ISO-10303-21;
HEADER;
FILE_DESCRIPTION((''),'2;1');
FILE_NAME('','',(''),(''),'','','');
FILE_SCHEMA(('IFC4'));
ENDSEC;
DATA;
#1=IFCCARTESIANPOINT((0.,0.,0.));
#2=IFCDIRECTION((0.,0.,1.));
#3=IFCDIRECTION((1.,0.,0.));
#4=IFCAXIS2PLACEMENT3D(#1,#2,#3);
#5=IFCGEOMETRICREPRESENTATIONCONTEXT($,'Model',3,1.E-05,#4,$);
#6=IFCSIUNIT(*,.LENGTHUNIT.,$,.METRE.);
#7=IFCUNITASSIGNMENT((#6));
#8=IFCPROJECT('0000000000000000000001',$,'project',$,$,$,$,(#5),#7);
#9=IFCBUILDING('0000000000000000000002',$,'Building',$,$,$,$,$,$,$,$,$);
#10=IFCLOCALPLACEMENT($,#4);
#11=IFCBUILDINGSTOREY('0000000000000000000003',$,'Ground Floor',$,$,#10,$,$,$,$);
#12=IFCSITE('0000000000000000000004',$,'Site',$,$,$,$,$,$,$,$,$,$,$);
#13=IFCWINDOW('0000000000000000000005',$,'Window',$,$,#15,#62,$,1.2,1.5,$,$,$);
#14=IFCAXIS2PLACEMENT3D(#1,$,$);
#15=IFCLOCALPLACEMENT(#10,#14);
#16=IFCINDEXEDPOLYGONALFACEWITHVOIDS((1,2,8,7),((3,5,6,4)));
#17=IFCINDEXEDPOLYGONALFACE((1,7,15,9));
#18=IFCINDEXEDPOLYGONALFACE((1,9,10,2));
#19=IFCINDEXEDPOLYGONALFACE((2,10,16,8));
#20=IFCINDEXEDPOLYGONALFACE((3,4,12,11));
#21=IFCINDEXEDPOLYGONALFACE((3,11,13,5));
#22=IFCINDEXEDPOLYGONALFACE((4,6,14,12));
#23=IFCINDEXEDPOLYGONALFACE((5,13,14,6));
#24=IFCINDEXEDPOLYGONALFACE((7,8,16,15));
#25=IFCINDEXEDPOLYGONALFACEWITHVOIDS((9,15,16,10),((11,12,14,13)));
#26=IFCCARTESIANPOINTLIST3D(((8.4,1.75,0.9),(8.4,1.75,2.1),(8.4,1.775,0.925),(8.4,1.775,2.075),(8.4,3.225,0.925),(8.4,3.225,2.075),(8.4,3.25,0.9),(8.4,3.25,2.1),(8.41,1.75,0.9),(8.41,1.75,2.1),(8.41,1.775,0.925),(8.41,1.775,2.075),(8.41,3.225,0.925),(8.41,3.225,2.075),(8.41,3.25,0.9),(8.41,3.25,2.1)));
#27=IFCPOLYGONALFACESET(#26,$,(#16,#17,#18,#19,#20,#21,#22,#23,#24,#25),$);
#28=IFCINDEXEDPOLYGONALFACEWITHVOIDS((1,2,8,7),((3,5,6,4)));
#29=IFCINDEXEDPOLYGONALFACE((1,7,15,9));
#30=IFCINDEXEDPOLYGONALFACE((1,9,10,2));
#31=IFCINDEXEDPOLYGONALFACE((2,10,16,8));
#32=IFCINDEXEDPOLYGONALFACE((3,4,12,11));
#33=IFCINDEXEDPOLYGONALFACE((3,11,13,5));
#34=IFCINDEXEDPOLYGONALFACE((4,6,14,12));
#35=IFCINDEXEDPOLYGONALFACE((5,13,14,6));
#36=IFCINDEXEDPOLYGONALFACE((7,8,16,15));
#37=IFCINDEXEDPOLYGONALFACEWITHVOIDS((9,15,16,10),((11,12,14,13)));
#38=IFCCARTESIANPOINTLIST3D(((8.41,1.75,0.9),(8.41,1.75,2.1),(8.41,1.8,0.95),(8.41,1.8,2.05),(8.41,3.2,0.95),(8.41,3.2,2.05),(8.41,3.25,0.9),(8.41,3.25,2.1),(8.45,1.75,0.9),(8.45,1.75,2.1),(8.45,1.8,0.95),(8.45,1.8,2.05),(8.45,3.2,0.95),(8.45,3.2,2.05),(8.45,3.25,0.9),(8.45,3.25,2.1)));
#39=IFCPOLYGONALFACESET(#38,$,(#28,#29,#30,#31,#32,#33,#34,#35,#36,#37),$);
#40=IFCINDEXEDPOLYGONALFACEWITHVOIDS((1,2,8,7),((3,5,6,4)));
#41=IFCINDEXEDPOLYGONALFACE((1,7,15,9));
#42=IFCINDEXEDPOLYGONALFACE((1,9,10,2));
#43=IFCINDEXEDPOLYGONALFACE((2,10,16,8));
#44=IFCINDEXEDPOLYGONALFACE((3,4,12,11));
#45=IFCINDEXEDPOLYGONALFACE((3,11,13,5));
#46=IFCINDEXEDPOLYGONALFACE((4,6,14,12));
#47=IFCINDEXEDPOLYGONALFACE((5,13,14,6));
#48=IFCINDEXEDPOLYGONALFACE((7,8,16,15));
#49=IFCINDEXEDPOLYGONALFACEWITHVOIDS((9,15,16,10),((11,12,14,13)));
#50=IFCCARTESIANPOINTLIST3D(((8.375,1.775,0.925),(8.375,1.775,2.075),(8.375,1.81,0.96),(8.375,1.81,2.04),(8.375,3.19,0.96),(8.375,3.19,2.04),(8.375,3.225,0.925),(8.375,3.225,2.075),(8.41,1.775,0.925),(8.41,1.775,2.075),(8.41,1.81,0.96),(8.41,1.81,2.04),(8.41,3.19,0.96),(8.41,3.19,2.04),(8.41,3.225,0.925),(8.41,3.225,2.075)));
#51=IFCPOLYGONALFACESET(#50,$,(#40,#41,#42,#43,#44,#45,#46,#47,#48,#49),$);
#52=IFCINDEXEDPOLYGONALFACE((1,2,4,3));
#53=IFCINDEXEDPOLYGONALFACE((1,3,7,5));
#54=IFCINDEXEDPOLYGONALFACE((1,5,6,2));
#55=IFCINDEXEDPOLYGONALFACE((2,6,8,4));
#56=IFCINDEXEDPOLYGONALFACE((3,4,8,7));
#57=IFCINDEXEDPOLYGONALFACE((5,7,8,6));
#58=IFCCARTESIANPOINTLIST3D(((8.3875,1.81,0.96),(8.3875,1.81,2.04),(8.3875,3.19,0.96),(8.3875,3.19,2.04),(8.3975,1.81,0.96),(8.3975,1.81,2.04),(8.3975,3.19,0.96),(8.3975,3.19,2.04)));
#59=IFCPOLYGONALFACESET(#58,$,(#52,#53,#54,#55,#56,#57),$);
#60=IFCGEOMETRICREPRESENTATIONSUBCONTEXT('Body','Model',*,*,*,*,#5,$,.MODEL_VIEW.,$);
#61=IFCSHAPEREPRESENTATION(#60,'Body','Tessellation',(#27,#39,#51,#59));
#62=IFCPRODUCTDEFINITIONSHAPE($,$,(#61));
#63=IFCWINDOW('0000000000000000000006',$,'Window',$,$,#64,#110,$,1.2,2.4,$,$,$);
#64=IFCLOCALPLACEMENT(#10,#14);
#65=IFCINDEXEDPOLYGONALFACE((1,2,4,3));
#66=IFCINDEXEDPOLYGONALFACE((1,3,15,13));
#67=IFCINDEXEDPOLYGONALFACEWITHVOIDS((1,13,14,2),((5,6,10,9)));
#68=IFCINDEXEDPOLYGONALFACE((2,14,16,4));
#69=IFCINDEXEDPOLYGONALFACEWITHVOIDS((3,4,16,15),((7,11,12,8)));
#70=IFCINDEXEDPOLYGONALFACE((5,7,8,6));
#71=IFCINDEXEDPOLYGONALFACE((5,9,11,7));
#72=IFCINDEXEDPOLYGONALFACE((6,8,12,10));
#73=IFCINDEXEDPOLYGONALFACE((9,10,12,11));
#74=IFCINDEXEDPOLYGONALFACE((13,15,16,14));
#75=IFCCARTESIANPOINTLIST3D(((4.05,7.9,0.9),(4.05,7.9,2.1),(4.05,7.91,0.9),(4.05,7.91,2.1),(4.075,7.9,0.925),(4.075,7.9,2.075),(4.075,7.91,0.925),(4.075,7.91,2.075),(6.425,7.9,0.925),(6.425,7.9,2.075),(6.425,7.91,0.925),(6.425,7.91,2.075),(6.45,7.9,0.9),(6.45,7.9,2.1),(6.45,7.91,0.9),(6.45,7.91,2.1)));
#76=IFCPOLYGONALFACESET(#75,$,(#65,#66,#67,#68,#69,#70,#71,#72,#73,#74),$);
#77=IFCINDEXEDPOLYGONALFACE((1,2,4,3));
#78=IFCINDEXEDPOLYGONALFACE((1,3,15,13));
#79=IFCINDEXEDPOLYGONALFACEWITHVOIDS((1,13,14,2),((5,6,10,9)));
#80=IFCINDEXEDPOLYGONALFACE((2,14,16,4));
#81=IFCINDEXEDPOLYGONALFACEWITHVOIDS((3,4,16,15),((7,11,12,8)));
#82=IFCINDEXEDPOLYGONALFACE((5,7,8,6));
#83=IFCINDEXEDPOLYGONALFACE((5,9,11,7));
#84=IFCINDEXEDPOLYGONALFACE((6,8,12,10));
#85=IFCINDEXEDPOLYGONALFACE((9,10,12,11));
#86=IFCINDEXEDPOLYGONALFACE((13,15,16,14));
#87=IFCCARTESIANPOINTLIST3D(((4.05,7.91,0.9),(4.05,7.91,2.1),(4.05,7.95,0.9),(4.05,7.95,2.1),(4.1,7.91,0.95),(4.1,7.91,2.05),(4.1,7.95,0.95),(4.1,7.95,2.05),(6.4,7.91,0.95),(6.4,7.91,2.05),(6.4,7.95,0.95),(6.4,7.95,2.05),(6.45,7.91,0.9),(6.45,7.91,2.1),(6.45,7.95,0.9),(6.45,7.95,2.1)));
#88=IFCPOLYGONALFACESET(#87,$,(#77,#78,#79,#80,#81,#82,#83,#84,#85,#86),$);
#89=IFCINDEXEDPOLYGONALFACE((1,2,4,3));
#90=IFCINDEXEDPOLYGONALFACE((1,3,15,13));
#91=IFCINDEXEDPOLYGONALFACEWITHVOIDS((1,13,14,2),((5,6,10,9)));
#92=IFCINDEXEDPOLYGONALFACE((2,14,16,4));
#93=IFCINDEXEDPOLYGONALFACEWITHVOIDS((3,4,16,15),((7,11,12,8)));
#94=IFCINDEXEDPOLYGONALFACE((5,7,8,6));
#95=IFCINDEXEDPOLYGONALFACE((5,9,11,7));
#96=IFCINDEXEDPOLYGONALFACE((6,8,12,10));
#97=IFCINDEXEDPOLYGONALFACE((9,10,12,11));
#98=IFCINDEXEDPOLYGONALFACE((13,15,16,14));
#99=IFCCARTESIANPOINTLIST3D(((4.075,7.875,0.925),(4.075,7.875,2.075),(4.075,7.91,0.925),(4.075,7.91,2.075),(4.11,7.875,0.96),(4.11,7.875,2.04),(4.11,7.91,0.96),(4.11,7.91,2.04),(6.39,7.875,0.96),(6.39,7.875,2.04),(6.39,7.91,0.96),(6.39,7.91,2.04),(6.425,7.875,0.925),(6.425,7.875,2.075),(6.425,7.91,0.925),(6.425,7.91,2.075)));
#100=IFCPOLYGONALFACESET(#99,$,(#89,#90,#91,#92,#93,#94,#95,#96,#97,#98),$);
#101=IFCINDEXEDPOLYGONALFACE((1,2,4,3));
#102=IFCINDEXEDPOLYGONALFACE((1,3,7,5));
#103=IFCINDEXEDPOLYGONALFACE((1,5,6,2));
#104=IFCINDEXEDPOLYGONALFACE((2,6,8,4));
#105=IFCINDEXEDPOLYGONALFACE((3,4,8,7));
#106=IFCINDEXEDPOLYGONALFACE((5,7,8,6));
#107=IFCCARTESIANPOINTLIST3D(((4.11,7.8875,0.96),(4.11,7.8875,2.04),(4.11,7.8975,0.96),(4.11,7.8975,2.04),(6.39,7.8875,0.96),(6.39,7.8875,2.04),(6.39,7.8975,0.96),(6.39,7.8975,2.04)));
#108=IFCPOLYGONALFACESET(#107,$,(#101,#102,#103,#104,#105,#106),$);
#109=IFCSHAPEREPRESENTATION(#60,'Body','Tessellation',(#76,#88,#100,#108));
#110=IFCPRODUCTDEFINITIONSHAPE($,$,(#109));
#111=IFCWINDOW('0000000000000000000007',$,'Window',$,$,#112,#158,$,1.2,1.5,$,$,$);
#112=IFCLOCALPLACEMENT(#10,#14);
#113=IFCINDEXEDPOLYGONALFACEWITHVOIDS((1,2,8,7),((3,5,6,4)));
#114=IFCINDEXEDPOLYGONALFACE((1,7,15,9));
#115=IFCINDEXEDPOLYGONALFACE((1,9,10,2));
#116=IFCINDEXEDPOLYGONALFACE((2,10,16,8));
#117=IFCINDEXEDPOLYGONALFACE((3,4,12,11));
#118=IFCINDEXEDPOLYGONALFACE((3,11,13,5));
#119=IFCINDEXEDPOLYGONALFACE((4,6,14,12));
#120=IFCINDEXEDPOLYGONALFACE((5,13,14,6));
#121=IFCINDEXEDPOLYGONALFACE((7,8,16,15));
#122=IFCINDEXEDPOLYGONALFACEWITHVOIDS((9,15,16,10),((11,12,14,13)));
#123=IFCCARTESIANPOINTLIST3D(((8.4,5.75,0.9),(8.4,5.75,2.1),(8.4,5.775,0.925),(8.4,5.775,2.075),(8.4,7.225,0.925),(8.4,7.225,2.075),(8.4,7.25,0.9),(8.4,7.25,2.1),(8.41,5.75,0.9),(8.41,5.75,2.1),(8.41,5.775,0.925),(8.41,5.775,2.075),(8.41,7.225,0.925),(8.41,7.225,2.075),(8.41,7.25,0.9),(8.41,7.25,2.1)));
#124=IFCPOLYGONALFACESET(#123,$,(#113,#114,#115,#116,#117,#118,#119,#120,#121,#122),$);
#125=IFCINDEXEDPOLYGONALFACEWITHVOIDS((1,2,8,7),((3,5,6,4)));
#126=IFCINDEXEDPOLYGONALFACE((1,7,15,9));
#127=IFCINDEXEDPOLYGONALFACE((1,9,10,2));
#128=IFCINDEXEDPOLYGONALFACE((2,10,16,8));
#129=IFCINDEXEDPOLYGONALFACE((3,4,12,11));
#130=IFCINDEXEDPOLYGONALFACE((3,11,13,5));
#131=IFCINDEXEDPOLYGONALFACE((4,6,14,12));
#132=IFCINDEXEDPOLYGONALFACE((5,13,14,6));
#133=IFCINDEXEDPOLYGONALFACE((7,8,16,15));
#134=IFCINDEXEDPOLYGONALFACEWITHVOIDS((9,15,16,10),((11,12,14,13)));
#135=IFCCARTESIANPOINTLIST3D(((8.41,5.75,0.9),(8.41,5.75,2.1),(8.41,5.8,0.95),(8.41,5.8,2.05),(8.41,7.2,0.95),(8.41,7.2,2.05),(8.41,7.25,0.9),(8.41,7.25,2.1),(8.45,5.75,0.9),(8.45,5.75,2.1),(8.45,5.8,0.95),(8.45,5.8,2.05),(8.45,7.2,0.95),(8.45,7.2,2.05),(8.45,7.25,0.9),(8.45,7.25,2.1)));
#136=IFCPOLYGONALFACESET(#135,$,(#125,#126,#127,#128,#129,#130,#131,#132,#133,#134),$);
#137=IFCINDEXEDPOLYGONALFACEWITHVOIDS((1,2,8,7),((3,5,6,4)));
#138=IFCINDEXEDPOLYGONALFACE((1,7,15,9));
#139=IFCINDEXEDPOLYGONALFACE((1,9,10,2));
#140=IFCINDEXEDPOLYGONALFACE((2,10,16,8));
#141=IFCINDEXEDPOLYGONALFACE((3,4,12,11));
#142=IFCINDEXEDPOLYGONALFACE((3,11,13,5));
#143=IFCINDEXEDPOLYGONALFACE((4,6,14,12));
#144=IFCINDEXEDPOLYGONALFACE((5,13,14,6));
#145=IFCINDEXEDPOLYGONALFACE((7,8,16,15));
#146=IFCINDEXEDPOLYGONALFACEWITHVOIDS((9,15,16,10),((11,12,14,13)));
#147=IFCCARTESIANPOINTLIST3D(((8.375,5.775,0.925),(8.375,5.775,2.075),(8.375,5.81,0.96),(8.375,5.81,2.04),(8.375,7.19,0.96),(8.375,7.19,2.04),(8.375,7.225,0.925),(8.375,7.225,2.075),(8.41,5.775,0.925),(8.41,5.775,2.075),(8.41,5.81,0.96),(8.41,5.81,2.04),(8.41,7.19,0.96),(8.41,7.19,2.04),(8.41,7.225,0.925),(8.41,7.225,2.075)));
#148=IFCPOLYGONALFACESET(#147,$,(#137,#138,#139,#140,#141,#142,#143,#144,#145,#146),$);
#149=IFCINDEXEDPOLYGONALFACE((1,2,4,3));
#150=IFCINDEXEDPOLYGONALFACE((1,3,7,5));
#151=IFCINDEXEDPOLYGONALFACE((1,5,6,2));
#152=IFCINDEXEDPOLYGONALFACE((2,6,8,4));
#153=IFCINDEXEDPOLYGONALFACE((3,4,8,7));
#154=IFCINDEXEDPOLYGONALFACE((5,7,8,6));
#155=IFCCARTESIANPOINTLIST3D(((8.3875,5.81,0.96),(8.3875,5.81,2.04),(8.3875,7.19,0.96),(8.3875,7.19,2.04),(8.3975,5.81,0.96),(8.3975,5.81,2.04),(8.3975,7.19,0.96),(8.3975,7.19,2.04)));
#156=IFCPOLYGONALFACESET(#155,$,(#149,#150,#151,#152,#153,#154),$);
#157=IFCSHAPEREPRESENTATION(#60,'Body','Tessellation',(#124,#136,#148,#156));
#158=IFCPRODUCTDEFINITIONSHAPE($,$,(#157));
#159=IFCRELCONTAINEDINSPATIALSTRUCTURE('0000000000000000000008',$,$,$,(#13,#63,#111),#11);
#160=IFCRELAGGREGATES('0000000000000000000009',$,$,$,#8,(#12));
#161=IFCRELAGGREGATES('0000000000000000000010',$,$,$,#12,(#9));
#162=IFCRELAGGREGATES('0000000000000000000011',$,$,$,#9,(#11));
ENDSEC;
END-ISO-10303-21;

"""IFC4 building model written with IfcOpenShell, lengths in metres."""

from ifc_helpers import new_model, si_unit, frame, origin_with_axes, place, context, subcontext, project, spatial, line, indexed_curve, outline, extrude, element, save


model = new_model("IFC4")

# Units and contexts
model_context = context("Model", 3, precision=1e-05, world=origin_with_axes())
body_context = subcontext(model_context, "Body", "Model", "MODEL_VIEW")
ifc_project = project(units=[si_unit("LENGTHUNIT", "METRE")], contexts=[model_context])

# Site, building, storey
site = spatial("IfcSite", under=ifc_project, Name="Site")
building = spatial("IfcBuilding", under=site, Name="Building")
storey_placement = place(None, origin_with_axes())
storey = spatial("IfcBuildingStorey", under=building, at=storey_placement, Name="Ground Floor")

# Windows
window_1_placement = place(storey_placement, frame((8.5, 1.75, 0.9), z_axis=(0.0, 0.0, 1.0), x_axis=(0.0, 1.0, 0.0)))
element("IfcWindow", 1, at=window_1_placement, inside=storey, Name="Window", OverallHeight=1.2, OverallWidth=1.5, context=body_context, shape_type="SweptSolid", body=[
    extrude(outline(indexed_curve([(0.0, 0.0), (1.5, 0.0), (1.5, 1.2), (0.0, 1.2)], segments=[line(1, 2, 3, 4, 1)]), holes=[indexed_curve([(0.025, 0.025), (1.475, 0.025), (1.475, 1.175), (0.025, 1.175)], segments=[line(1, 2, 3, 4, 1)])]), frame((0.0, 0.09, 0.0), z_axis=(0.0, -1.0, 0.0), x_axis=(1.0, 0.0, 0.0)), (0.0, 0.0, -1.0), 0.01),
    extrude(outline(indexed_curve([(0.0, 0.0), (1.5, 0.0), (1.5, 1.2), (0.0, 1.2)], segments=[line(1, 2, 3, 4, 1)]), holes=[indexed_curve([(0.05, 0.05), (1.45, 0.05), (1.45, 1.15), (0.05, 1.15)], segments=[line(1, 2, 3, 4, 1)])]), frame((0.0, 0.05, 0.0), z_axis=(0.0, -1.0, 0.0), x_axis=(1.0, 0.0, 0.0)), (0.0, 0.0, -1.0), 0.04),
    extrude(outline(indexed_curve([(0.0, 0.0), (1.45, 0.0), (1.45, 1.15), (0.0, 1.15)], segments=[line(1, 2, 3, 4, 1)]), holes=[indexed_curve([(0.035, 0.035), (1.415, 0.035), (1.415, 1.115), (0.035, 1.115)], segments=[line(1, 2, 3, 4, 1)])]), frame((0.025, 0.09, 0.025), z_axis=(0.0, -1.0, 0.0), x_axis=(1.0, 0.0, 0.0)), (0.0, 0.0, -1.0), 0.035),
    extrude(outline(indexed_curve([(0.035, 0.035), (1.415, 0.035), (1.415, 1.115), (0.035, 1.115)], segments=[line(1, 2, 3, 4, 1)])), frame((0.025, 0.1025, 0.025), z_axis=(0.0, -1.0, 0.0), x_axis=(1.0, 0.0, 0.0)), (0.0, 0.0, -1.0), 0.01),
])
window_2_placement = place(storey_placement, frame((6.45, 8.0, 0.9), z_axis=(0.0, 0.0, 1.0), x_axis=(-1.0, 0.0, 0.0)))
element("IfcWindow", 2, at=window_2_placement, inside=storey, Name="Window", OverallHeight=1.2, OverallWidth=2.4, context=body_context, shape_type="SweptSolid", body=[
    extrude(outline(indexed_curve([(0.0, 0.0), (2.4, 0.0), (2.4, 1.2), (0.0, 1.2)], segments=[line(1, 2, 3, 4, 1)]), holes=[indexed_curve([(0.025, 0.025), (2.375, 0.025), (2.375, 1.175), (0.025, 1.175)], segments=[line(1, 2, 3, 4, 1)])]), frame((0.0, 0.09, 0.0), z_axis=(0.0, -1.0, 0.0), x_axis=(1.0, 0.0, 0.0)), (0.0, 0.0, -1.0), 0.01),
    extrude(outline(indexed_curve([(0.0, 0.0), (2.4, 0.0), (2.4, 1.2), (0.0, 1.2)], segments=[line(1, 2, 3, 4, 1)]), holes=[indexed_curve([(0.05, 0.05), (2.35, 0.05), (2.35, 1.15), (0.05, 1.15)], segments=[line(1, 2, 3, 4, 1)])]), frame((0.0, 0.05, 0.0), z_axis=(0.0, -1.0, 0.0), x_axis=(1.0, 0.0, 0.0)), (0.0, 0.0, -1.0), 0.04),
    extrude(outline(indexed_curve([(0.0, 0.0), (2.35, 0.0), (2.35, 1.15), (0.0, 1.15)], segments=[line(1, 2, 3, 4, 1)]), holes=[indexed_curve([(0.035, 0.035), (2.315, 0.035), (2.315, 1.115), (0.035, 1.115)], segments=[line(1, 2, 3, 4, 1)])]), frame((0.025, 0.09, 0.025), z_axis=(0.0, -1.0, 0.0), x_axis=(1.0, 0.0, 0.0)), (0.0, 0.0, -1.0), 0.035),
    extrude(outline(indexed_curve([(0.035, 0.035), (2.315, 0.035), (2.315, 1.115), (0.035, 1.115)], segments=[line(1, 2, 3, 4, 1)])), frame((0.025, 0.1025, 0.025), z_axis=(0.0, -1.0, 0.0), x_axis=(1.0, 0.0, 0.0)), (0.0, 0.0, -1.0), 0.01),
])
window_3_placement = place(storey_placement, frame((8.5, 5.75, 0.9), z_axis=(0.0, 0.0, 1.0), x_axis=(0.0, 1.0, 0.0)))
element("IfcWindow", 3, at=window_3_placement, inside=storey, Name="Window", OverallHeight=1.2, OverallWidth=1.5, context=body_context, shape_type="SweptSolid", body=[
    extrude(outline(indexed_curve([(0.0, 0.0), (1.5, 0.0), (1.5, 1.2), (0.0, 1.2)], segments=[line(1, 2, 3, 4, 1)]), holes=[indexed_curve([(0.025, 0.025), (1.475, 0.025), (1.475, 1.175), (0.025, 1.175)], segments=[line(1, 2, 3, 4, 1)])]), frame((0.0, 0.09, 0.0), z_axis=(0.0, -1.0, 0.0), x_axis=(1.0, 0.0, 0.0)), (0.0, 0.0, -1.0), 0.01),
    extrude(outline(indexed_curve([(0.0, 0.0), (1.5, 0.0), (1.5, 1.2), (0.0, 1.2)], segments=[line(1, 2, 3, 4, 1)]), holes=[indexed_curve([(0.05, 0.05), (1.45, 0.05), (1.45, 1.15), (0.05, 1.15)], segments=[line(1, 2, 3, 4, 1)])]), frame((0.0, 0.05, 0.0), z_axis=(0.0, -1.0, 0.0), x_axis=(1.0, 0.0, 0.0)), (0.0, 0.0, -1.0), 0.04),
    extrude(outline(indexed_curve([(0.0, 0.0), (1.45, 0.0), (1.45, 1.15), (0.0, 1.15)], segments=[line(1, 2, 3, 4, 1)]), holes=[indexed_curve([(0.035, 0.035), (1.415, 0.035), (1.415, 1.115), (0.035, 1.115)], segments=[line(1, 2, 3, 4, 1)])]), frame((0.025, 0.09, 0.025), z_axis=(0.0, -1.0, 0.0), x_axis=(1.0, 0.0, 0.0)), (0.0, 0.0, -1.0), 0.035),
    extrude(outline(indexed_curve([(0.035, 0.035), (1.415, 0.035), (1.415, 1.115), (0.035, 1.115)], segments=[line(1, 2, 3, 4, 1)])), frame((0.025, 0.1025, 0.025), z_axis=(0.0, -1.0, 0.0), x_axis=(1.0, 0.0, 0.0)), (0.0, 0.0, -1.0), 0.01),
])

save(model, "model.ifc")
